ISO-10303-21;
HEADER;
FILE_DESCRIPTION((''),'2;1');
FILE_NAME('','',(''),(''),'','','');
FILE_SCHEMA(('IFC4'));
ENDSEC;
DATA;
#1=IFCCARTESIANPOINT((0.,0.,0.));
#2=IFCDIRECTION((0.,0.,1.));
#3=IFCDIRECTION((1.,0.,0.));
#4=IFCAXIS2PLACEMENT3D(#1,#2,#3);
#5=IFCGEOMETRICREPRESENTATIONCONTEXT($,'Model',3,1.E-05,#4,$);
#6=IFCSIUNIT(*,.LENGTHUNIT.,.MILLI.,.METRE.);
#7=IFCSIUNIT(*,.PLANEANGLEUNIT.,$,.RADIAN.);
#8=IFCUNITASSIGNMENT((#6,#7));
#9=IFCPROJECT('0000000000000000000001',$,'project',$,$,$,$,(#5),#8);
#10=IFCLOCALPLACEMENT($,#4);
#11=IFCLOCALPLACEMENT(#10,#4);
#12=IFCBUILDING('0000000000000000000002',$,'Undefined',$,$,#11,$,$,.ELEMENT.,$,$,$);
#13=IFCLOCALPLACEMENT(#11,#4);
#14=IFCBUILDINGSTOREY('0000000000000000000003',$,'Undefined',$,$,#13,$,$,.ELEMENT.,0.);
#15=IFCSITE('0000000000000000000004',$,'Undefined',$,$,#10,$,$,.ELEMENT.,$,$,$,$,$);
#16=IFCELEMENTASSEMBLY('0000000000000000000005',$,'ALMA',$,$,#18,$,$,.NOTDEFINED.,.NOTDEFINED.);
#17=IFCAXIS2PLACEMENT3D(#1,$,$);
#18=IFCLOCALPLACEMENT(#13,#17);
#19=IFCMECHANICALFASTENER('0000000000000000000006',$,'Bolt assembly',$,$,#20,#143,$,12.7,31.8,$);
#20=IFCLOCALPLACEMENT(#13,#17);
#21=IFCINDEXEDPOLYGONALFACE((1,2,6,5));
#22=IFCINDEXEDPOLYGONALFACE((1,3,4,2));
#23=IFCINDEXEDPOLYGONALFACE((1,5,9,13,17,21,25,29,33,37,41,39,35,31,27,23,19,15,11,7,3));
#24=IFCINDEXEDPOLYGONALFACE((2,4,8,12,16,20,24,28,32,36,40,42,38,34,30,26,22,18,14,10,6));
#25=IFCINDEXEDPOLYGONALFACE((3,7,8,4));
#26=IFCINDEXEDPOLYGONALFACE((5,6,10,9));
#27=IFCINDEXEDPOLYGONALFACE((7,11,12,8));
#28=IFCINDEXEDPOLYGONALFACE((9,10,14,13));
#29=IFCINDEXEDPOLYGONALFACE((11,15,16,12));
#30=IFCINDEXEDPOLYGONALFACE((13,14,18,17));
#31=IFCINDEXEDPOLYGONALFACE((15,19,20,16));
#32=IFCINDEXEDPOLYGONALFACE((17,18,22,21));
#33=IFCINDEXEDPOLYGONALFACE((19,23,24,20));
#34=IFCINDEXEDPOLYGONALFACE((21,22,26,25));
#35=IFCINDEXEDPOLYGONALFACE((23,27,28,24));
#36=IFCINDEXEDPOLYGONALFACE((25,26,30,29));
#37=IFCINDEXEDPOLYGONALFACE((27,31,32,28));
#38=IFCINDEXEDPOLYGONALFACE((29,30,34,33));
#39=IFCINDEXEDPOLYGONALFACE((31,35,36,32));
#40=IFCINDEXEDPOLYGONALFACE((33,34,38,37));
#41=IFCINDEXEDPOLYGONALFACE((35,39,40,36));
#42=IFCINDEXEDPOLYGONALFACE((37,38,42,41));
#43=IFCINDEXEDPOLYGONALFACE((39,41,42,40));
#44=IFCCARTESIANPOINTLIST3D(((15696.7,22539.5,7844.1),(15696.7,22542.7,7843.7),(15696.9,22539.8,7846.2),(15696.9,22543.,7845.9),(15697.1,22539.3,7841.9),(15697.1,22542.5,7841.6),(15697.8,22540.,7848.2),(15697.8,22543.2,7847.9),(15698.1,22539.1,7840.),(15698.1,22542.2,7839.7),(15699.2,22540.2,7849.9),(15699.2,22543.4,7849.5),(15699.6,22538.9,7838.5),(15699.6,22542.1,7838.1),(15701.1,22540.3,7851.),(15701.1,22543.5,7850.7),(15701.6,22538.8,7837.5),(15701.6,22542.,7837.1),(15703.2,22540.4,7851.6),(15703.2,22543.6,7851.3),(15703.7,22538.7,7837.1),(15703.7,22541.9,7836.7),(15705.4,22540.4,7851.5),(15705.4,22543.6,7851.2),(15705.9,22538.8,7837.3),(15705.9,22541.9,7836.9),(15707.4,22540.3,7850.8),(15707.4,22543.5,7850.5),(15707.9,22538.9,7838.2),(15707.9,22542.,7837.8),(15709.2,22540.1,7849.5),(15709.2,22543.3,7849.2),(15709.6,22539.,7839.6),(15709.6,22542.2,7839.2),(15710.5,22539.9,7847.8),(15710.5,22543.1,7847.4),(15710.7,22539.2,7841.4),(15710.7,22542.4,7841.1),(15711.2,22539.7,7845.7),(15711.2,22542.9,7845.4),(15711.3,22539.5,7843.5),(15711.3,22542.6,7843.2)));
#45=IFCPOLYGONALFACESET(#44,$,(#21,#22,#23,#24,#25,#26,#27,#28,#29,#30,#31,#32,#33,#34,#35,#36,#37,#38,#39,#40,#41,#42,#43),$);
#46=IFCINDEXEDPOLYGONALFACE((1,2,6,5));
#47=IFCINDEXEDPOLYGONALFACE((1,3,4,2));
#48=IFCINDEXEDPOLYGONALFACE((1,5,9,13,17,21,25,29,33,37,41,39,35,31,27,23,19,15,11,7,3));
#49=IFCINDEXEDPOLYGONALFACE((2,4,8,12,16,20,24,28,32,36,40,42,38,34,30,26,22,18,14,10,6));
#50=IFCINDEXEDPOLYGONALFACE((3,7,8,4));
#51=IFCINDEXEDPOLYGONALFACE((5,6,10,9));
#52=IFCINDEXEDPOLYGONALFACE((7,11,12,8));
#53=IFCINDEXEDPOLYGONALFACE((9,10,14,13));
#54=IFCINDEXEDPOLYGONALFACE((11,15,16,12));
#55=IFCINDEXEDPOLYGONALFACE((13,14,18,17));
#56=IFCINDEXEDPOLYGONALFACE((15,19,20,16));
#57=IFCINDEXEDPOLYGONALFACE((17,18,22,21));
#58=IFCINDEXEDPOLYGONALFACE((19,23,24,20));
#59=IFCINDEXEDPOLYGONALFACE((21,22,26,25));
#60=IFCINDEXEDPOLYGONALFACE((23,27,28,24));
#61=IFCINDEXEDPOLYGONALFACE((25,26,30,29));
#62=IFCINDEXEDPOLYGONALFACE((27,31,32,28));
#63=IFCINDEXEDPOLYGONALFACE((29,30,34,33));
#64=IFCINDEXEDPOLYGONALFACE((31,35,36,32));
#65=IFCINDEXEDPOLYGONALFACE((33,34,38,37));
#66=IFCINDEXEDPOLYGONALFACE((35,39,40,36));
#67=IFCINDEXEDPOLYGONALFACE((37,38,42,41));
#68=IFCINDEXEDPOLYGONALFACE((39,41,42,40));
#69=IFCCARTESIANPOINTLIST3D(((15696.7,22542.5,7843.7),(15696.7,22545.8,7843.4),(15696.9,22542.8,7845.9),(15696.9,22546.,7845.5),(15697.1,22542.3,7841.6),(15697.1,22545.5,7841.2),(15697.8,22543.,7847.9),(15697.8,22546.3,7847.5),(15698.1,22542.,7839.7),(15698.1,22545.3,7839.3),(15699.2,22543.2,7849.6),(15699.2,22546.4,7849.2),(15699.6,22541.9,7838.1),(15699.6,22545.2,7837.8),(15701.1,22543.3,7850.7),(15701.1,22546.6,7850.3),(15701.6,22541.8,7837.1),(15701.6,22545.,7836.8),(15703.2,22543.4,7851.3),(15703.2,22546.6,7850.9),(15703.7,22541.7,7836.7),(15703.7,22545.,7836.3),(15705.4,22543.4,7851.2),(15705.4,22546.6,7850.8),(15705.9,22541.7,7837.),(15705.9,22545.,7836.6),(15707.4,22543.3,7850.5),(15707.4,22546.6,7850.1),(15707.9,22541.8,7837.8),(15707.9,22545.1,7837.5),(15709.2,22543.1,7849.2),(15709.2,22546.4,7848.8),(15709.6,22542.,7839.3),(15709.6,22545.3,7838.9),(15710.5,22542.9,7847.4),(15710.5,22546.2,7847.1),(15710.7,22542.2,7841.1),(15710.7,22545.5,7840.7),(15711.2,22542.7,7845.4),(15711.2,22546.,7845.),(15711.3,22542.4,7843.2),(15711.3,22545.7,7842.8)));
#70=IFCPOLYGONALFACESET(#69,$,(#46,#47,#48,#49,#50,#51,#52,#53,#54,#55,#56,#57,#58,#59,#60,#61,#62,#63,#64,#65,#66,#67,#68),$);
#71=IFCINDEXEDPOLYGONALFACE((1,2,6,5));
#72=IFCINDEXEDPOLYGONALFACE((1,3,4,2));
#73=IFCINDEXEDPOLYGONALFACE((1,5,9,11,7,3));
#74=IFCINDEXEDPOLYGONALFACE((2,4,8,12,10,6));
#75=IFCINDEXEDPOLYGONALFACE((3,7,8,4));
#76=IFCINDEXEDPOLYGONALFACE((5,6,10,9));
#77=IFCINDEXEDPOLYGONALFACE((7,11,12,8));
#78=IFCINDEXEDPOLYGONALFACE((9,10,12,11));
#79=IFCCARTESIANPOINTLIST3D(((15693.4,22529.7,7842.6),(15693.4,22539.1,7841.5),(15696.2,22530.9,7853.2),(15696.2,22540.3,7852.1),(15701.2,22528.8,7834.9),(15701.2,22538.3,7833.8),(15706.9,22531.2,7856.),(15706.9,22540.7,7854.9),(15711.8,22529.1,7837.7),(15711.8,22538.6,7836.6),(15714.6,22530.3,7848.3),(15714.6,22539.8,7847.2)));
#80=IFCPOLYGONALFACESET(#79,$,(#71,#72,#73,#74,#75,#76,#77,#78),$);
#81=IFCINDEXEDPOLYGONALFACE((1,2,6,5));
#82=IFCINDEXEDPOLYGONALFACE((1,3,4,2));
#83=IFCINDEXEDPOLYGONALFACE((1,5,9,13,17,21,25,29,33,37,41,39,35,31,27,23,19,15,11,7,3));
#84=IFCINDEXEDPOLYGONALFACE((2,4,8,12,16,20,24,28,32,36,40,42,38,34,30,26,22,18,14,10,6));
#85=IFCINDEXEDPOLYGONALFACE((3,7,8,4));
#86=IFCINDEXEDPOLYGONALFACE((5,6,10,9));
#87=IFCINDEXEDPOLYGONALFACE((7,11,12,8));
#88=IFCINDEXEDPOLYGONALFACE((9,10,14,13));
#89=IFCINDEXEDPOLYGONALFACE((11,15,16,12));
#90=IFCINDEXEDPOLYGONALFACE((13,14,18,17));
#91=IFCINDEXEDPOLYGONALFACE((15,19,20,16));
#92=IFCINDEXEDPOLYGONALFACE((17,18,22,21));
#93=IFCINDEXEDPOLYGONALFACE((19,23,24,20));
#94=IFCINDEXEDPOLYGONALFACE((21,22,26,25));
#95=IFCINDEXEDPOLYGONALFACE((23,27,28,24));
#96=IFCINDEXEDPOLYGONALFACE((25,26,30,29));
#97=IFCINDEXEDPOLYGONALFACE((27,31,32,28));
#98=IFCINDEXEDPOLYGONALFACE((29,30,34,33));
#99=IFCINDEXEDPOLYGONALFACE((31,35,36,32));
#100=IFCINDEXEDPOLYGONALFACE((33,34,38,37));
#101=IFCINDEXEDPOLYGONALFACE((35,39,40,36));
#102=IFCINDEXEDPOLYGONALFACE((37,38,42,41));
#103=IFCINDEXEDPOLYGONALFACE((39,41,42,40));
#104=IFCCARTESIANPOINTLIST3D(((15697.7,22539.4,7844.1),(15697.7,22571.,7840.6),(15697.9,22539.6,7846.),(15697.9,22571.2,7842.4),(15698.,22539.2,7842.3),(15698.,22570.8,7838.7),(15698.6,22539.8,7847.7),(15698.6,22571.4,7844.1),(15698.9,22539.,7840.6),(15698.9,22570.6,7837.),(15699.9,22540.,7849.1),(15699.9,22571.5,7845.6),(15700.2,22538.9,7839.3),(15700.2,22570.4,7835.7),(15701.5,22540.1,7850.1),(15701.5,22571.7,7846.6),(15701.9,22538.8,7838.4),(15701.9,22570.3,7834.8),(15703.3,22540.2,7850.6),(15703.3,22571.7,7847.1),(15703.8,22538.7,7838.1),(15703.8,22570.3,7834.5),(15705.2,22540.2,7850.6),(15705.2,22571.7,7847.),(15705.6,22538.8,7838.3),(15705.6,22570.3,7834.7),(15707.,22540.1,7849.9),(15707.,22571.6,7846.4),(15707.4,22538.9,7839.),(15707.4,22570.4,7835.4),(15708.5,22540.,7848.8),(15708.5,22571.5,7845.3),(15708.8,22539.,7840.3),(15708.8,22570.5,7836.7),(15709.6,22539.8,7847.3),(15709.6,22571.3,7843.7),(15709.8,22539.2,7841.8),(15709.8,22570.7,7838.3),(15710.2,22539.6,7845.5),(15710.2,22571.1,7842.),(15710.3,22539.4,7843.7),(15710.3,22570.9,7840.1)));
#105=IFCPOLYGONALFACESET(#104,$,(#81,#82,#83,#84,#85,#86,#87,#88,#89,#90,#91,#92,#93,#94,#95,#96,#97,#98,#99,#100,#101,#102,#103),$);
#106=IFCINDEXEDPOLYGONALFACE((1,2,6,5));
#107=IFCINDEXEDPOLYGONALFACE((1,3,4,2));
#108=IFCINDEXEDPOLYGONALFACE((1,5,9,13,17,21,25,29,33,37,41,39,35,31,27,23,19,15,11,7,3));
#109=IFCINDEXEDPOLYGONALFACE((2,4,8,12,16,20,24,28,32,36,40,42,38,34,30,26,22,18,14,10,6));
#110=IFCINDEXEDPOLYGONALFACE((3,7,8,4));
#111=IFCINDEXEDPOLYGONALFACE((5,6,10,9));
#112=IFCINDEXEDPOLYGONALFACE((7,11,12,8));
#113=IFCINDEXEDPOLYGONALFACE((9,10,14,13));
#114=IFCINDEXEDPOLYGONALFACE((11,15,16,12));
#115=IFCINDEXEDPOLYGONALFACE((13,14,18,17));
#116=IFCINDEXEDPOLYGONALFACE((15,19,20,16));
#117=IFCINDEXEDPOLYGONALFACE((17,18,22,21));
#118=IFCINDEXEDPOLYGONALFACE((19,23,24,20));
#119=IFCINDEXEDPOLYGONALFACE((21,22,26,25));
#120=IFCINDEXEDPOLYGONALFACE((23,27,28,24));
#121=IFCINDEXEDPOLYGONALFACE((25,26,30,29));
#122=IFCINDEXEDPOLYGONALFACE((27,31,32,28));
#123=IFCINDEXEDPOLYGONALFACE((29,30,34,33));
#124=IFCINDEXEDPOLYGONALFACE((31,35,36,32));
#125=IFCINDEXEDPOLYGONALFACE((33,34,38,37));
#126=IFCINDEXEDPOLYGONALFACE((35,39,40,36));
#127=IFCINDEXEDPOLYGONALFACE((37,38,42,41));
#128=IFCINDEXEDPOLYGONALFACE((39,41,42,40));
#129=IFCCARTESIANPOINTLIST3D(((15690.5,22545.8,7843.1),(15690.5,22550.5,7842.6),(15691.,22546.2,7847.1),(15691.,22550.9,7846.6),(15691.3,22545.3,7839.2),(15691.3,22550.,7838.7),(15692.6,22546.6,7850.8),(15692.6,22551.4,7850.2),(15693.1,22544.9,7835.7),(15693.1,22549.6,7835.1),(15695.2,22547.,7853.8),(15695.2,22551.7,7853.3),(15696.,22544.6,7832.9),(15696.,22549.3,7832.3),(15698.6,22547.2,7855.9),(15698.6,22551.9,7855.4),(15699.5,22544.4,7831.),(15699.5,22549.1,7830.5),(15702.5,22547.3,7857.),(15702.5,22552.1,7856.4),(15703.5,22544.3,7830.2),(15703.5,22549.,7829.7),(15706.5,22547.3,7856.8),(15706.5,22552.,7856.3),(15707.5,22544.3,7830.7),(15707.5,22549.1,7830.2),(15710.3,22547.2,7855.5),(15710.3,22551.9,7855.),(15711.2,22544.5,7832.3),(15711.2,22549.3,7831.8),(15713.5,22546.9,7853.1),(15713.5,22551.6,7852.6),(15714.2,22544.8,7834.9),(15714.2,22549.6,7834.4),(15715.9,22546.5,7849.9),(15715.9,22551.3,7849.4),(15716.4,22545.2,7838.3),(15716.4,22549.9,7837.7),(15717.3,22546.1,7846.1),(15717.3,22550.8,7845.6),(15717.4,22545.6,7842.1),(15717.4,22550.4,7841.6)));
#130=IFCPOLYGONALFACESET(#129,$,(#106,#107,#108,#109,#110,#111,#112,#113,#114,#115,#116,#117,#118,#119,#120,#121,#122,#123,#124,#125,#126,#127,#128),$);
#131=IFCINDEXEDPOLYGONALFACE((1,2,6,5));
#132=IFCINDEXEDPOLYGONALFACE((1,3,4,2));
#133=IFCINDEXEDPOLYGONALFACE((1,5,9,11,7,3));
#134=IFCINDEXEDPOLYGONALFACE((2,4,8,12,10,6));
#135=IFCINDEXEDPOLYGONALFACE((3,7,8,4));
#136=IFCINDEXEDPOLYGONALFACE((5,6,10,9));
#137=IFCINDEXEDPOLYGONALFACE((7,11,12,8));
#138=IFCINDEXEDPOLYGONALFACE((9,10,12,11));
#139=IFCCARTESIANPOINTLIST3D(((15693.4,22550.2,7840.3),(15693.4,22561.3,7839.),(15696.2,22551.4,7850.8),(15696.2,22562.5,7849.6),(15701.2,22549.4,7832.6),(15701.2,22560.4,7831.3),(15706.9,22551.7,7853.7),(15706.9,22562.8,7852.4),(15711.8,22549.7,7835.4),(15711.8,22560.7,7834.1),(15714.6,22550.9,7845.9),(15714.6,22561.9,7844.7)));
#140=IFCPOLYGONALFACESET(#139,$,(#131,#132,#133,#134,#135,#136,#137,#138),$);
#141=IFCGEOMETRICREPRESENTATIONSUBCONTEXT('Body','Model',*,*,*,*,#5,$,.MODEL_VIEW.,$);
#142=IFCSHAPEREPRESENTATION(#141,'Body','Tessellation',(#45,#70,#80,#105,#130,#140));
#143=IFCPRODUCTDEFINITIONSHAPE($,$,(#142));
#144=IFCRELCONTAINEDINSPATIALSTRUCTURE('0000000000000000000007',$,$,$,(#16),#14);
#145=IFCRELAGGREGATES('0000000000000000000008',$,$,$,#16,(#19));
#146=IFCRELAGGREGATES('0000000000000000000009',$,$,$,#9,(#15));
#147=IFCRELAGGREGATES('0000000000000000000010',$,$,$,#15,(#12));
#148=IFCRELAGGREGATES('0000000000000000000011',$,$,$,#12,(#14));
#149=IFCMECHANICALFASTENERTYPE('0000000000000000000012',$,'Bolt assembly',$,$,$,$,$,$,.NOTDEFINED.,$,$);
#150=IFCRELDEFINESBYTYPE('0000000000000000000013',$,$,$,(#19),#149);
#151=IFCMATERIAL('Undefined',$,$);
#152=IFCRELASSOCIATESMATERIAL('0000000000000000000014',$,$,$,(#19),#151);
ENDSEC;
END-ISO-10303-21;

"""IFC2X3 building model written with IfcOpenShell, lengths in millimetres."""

from ifc_helpers import new_model, si_unit, frame, origin_with_axes, origin_2d_with_axis, place, context, subcontext, project, spatial, polyline, circle, outline, extrude, source, transform, mapped, material, type_object, element, aggregate, save


model = new_model("IFC2X3")

# Units and contexts
model_context = context("Model", 3, precision=1e-05, world=origin_with_axes())
body_context = subcontext(model_context, "Body", "Model", "MODEL_VIEW")
ifc_project = project(units=[si_unit("LENGTHUNIT", "METRE", prefix="MILLI"), si_unit("PLANEANGLEUNIT", "RADIAN")], contexts=[model_context])

# Site, building, storey
site_placement = place(None, origin_with_axes())
site = spatial("IfcSite", under=ifc_project, at=site_placement, Name="Undefined", CompositionType="ELEMENT")
building_placement = place(site_placement, origin_with_axes())
building = spatial("IfcBuilding", under=site, at=building_placement, Name="Undefined", CompositionType="ELEMENT")
storey_placement = place(building_placement, origin_with_axes())
storey = spatial("IfcBuildingStorey", under=building, at=storey_placement, Name="Undefined", CompositionType="ELEMENT", Elevation=0.0)

# Element assembly
assembly_1_placement = place(storey_placement, origin_with_axes())
assembly_1 = element("IfcElementAssembly", 1, at=assembly_1_placement, inside=storey, Name="ALMA", AssemblyPlace="NOTDEFINED", PredefinedType="NOTDEFINED")

# Mechanical fastener
ifc_material_1 = material(Name="Undefined")
mechanical_fastener_type = type_object("IfcMechanicalFastenerType", Name="Bolt assembly")
shared_shape_1 = source(origin_with_axes(), body_context, "Body", "SweptSolid", [
    extrude(circle(Radius=7.3, at=origin_2d_with_axis()), frame((0.0, 0.1, 0.0), z_axis=(0.0, 1.0, 0.0), x_axis=(1.0, 0.0, 0.0)), (0.0, 0.0, 1.0), 3.2),
    extrude(circle(Radius=7.3, at=origin_2d_with_axis()), frame((0.0, 3.1, 0.0), z_axis=(0.0, 1.0, 0.0), x_axis=(1.0, 0.0, 0.0)), (0.0, 0.0, 1.0), 3.3),
    extrude(outline(polyline([(9.5, -5.5), (9.5, 5.5), (0.0, 11.0), (-9.5, 5.5), (-9.5, -5.5), (0.0, -11.0), (9.5, -5.5)])), frame((0.0, -9.5, 0.0), z_axis=(0.0, 1.0, 0.0), x_axis=(1.0, 0.0, 0.0)), (0.0, 0.0, 1.0), 9.5),
    extrude(circle(Radius=6.3, at=origin_2d_with_axis()), frame((0.0, 0.0, 0.0), z_axis=(0.0, 1.0, 0.0), x_axis=(1.0, 0.0, 0.0)), (0.0, 0.0, 1.0), 31.8),
    extrude(circle(Radius=13.5, at=origin_2d_with_axis()), frame((0.0, 6.4, 0.0), z_axis=(0.0, 1.0, 0.0), x_axis=(1.0, 0.0, 0.0)), (0.0, 0.0, 1.0), 4.8),
    extrude(outline(polyline([(9.5, -5.5), (9.5, 5.5), (0.0, 11.0), (-9.5, 5.5), (-9.5, -5.5), (0.0, -11.0), (9.5, -5.5)])), frame((0.0, 11.2, 0.0), z_axis=(0.0, 1.0, 0.0), x_axis=(1.0, 0.0, 0.0)), (0.0, 0.0, 1.0), 11.1),
])
mechanical_fastener_1_placement = place(assembly_1_placement, frame((15704.0, 22539.5, 7844.4), z_axis=(-0.707107, 0.079651, 0.702606), x_axis=(0.707107, 0.079651, 0.702606)))
mechanical_fastener_1 = element("IfcMechanicalFastener", 2, at=mechanical_fastener_1_placement, type_object=mechanical_fastener_type, material=ifc_material_1, Name="Bolt assembly", NominalDiameter=12.7, NominalLength=31.8, context=body_context, shape_type="MappedRepresentation", body=[
    mapped(shared_shape_1, transform((0.0, 0.0, 0.0))),
])

aggregate(assembly_1, [mechanical_fastener_1])

save(model, "model.ifc")
